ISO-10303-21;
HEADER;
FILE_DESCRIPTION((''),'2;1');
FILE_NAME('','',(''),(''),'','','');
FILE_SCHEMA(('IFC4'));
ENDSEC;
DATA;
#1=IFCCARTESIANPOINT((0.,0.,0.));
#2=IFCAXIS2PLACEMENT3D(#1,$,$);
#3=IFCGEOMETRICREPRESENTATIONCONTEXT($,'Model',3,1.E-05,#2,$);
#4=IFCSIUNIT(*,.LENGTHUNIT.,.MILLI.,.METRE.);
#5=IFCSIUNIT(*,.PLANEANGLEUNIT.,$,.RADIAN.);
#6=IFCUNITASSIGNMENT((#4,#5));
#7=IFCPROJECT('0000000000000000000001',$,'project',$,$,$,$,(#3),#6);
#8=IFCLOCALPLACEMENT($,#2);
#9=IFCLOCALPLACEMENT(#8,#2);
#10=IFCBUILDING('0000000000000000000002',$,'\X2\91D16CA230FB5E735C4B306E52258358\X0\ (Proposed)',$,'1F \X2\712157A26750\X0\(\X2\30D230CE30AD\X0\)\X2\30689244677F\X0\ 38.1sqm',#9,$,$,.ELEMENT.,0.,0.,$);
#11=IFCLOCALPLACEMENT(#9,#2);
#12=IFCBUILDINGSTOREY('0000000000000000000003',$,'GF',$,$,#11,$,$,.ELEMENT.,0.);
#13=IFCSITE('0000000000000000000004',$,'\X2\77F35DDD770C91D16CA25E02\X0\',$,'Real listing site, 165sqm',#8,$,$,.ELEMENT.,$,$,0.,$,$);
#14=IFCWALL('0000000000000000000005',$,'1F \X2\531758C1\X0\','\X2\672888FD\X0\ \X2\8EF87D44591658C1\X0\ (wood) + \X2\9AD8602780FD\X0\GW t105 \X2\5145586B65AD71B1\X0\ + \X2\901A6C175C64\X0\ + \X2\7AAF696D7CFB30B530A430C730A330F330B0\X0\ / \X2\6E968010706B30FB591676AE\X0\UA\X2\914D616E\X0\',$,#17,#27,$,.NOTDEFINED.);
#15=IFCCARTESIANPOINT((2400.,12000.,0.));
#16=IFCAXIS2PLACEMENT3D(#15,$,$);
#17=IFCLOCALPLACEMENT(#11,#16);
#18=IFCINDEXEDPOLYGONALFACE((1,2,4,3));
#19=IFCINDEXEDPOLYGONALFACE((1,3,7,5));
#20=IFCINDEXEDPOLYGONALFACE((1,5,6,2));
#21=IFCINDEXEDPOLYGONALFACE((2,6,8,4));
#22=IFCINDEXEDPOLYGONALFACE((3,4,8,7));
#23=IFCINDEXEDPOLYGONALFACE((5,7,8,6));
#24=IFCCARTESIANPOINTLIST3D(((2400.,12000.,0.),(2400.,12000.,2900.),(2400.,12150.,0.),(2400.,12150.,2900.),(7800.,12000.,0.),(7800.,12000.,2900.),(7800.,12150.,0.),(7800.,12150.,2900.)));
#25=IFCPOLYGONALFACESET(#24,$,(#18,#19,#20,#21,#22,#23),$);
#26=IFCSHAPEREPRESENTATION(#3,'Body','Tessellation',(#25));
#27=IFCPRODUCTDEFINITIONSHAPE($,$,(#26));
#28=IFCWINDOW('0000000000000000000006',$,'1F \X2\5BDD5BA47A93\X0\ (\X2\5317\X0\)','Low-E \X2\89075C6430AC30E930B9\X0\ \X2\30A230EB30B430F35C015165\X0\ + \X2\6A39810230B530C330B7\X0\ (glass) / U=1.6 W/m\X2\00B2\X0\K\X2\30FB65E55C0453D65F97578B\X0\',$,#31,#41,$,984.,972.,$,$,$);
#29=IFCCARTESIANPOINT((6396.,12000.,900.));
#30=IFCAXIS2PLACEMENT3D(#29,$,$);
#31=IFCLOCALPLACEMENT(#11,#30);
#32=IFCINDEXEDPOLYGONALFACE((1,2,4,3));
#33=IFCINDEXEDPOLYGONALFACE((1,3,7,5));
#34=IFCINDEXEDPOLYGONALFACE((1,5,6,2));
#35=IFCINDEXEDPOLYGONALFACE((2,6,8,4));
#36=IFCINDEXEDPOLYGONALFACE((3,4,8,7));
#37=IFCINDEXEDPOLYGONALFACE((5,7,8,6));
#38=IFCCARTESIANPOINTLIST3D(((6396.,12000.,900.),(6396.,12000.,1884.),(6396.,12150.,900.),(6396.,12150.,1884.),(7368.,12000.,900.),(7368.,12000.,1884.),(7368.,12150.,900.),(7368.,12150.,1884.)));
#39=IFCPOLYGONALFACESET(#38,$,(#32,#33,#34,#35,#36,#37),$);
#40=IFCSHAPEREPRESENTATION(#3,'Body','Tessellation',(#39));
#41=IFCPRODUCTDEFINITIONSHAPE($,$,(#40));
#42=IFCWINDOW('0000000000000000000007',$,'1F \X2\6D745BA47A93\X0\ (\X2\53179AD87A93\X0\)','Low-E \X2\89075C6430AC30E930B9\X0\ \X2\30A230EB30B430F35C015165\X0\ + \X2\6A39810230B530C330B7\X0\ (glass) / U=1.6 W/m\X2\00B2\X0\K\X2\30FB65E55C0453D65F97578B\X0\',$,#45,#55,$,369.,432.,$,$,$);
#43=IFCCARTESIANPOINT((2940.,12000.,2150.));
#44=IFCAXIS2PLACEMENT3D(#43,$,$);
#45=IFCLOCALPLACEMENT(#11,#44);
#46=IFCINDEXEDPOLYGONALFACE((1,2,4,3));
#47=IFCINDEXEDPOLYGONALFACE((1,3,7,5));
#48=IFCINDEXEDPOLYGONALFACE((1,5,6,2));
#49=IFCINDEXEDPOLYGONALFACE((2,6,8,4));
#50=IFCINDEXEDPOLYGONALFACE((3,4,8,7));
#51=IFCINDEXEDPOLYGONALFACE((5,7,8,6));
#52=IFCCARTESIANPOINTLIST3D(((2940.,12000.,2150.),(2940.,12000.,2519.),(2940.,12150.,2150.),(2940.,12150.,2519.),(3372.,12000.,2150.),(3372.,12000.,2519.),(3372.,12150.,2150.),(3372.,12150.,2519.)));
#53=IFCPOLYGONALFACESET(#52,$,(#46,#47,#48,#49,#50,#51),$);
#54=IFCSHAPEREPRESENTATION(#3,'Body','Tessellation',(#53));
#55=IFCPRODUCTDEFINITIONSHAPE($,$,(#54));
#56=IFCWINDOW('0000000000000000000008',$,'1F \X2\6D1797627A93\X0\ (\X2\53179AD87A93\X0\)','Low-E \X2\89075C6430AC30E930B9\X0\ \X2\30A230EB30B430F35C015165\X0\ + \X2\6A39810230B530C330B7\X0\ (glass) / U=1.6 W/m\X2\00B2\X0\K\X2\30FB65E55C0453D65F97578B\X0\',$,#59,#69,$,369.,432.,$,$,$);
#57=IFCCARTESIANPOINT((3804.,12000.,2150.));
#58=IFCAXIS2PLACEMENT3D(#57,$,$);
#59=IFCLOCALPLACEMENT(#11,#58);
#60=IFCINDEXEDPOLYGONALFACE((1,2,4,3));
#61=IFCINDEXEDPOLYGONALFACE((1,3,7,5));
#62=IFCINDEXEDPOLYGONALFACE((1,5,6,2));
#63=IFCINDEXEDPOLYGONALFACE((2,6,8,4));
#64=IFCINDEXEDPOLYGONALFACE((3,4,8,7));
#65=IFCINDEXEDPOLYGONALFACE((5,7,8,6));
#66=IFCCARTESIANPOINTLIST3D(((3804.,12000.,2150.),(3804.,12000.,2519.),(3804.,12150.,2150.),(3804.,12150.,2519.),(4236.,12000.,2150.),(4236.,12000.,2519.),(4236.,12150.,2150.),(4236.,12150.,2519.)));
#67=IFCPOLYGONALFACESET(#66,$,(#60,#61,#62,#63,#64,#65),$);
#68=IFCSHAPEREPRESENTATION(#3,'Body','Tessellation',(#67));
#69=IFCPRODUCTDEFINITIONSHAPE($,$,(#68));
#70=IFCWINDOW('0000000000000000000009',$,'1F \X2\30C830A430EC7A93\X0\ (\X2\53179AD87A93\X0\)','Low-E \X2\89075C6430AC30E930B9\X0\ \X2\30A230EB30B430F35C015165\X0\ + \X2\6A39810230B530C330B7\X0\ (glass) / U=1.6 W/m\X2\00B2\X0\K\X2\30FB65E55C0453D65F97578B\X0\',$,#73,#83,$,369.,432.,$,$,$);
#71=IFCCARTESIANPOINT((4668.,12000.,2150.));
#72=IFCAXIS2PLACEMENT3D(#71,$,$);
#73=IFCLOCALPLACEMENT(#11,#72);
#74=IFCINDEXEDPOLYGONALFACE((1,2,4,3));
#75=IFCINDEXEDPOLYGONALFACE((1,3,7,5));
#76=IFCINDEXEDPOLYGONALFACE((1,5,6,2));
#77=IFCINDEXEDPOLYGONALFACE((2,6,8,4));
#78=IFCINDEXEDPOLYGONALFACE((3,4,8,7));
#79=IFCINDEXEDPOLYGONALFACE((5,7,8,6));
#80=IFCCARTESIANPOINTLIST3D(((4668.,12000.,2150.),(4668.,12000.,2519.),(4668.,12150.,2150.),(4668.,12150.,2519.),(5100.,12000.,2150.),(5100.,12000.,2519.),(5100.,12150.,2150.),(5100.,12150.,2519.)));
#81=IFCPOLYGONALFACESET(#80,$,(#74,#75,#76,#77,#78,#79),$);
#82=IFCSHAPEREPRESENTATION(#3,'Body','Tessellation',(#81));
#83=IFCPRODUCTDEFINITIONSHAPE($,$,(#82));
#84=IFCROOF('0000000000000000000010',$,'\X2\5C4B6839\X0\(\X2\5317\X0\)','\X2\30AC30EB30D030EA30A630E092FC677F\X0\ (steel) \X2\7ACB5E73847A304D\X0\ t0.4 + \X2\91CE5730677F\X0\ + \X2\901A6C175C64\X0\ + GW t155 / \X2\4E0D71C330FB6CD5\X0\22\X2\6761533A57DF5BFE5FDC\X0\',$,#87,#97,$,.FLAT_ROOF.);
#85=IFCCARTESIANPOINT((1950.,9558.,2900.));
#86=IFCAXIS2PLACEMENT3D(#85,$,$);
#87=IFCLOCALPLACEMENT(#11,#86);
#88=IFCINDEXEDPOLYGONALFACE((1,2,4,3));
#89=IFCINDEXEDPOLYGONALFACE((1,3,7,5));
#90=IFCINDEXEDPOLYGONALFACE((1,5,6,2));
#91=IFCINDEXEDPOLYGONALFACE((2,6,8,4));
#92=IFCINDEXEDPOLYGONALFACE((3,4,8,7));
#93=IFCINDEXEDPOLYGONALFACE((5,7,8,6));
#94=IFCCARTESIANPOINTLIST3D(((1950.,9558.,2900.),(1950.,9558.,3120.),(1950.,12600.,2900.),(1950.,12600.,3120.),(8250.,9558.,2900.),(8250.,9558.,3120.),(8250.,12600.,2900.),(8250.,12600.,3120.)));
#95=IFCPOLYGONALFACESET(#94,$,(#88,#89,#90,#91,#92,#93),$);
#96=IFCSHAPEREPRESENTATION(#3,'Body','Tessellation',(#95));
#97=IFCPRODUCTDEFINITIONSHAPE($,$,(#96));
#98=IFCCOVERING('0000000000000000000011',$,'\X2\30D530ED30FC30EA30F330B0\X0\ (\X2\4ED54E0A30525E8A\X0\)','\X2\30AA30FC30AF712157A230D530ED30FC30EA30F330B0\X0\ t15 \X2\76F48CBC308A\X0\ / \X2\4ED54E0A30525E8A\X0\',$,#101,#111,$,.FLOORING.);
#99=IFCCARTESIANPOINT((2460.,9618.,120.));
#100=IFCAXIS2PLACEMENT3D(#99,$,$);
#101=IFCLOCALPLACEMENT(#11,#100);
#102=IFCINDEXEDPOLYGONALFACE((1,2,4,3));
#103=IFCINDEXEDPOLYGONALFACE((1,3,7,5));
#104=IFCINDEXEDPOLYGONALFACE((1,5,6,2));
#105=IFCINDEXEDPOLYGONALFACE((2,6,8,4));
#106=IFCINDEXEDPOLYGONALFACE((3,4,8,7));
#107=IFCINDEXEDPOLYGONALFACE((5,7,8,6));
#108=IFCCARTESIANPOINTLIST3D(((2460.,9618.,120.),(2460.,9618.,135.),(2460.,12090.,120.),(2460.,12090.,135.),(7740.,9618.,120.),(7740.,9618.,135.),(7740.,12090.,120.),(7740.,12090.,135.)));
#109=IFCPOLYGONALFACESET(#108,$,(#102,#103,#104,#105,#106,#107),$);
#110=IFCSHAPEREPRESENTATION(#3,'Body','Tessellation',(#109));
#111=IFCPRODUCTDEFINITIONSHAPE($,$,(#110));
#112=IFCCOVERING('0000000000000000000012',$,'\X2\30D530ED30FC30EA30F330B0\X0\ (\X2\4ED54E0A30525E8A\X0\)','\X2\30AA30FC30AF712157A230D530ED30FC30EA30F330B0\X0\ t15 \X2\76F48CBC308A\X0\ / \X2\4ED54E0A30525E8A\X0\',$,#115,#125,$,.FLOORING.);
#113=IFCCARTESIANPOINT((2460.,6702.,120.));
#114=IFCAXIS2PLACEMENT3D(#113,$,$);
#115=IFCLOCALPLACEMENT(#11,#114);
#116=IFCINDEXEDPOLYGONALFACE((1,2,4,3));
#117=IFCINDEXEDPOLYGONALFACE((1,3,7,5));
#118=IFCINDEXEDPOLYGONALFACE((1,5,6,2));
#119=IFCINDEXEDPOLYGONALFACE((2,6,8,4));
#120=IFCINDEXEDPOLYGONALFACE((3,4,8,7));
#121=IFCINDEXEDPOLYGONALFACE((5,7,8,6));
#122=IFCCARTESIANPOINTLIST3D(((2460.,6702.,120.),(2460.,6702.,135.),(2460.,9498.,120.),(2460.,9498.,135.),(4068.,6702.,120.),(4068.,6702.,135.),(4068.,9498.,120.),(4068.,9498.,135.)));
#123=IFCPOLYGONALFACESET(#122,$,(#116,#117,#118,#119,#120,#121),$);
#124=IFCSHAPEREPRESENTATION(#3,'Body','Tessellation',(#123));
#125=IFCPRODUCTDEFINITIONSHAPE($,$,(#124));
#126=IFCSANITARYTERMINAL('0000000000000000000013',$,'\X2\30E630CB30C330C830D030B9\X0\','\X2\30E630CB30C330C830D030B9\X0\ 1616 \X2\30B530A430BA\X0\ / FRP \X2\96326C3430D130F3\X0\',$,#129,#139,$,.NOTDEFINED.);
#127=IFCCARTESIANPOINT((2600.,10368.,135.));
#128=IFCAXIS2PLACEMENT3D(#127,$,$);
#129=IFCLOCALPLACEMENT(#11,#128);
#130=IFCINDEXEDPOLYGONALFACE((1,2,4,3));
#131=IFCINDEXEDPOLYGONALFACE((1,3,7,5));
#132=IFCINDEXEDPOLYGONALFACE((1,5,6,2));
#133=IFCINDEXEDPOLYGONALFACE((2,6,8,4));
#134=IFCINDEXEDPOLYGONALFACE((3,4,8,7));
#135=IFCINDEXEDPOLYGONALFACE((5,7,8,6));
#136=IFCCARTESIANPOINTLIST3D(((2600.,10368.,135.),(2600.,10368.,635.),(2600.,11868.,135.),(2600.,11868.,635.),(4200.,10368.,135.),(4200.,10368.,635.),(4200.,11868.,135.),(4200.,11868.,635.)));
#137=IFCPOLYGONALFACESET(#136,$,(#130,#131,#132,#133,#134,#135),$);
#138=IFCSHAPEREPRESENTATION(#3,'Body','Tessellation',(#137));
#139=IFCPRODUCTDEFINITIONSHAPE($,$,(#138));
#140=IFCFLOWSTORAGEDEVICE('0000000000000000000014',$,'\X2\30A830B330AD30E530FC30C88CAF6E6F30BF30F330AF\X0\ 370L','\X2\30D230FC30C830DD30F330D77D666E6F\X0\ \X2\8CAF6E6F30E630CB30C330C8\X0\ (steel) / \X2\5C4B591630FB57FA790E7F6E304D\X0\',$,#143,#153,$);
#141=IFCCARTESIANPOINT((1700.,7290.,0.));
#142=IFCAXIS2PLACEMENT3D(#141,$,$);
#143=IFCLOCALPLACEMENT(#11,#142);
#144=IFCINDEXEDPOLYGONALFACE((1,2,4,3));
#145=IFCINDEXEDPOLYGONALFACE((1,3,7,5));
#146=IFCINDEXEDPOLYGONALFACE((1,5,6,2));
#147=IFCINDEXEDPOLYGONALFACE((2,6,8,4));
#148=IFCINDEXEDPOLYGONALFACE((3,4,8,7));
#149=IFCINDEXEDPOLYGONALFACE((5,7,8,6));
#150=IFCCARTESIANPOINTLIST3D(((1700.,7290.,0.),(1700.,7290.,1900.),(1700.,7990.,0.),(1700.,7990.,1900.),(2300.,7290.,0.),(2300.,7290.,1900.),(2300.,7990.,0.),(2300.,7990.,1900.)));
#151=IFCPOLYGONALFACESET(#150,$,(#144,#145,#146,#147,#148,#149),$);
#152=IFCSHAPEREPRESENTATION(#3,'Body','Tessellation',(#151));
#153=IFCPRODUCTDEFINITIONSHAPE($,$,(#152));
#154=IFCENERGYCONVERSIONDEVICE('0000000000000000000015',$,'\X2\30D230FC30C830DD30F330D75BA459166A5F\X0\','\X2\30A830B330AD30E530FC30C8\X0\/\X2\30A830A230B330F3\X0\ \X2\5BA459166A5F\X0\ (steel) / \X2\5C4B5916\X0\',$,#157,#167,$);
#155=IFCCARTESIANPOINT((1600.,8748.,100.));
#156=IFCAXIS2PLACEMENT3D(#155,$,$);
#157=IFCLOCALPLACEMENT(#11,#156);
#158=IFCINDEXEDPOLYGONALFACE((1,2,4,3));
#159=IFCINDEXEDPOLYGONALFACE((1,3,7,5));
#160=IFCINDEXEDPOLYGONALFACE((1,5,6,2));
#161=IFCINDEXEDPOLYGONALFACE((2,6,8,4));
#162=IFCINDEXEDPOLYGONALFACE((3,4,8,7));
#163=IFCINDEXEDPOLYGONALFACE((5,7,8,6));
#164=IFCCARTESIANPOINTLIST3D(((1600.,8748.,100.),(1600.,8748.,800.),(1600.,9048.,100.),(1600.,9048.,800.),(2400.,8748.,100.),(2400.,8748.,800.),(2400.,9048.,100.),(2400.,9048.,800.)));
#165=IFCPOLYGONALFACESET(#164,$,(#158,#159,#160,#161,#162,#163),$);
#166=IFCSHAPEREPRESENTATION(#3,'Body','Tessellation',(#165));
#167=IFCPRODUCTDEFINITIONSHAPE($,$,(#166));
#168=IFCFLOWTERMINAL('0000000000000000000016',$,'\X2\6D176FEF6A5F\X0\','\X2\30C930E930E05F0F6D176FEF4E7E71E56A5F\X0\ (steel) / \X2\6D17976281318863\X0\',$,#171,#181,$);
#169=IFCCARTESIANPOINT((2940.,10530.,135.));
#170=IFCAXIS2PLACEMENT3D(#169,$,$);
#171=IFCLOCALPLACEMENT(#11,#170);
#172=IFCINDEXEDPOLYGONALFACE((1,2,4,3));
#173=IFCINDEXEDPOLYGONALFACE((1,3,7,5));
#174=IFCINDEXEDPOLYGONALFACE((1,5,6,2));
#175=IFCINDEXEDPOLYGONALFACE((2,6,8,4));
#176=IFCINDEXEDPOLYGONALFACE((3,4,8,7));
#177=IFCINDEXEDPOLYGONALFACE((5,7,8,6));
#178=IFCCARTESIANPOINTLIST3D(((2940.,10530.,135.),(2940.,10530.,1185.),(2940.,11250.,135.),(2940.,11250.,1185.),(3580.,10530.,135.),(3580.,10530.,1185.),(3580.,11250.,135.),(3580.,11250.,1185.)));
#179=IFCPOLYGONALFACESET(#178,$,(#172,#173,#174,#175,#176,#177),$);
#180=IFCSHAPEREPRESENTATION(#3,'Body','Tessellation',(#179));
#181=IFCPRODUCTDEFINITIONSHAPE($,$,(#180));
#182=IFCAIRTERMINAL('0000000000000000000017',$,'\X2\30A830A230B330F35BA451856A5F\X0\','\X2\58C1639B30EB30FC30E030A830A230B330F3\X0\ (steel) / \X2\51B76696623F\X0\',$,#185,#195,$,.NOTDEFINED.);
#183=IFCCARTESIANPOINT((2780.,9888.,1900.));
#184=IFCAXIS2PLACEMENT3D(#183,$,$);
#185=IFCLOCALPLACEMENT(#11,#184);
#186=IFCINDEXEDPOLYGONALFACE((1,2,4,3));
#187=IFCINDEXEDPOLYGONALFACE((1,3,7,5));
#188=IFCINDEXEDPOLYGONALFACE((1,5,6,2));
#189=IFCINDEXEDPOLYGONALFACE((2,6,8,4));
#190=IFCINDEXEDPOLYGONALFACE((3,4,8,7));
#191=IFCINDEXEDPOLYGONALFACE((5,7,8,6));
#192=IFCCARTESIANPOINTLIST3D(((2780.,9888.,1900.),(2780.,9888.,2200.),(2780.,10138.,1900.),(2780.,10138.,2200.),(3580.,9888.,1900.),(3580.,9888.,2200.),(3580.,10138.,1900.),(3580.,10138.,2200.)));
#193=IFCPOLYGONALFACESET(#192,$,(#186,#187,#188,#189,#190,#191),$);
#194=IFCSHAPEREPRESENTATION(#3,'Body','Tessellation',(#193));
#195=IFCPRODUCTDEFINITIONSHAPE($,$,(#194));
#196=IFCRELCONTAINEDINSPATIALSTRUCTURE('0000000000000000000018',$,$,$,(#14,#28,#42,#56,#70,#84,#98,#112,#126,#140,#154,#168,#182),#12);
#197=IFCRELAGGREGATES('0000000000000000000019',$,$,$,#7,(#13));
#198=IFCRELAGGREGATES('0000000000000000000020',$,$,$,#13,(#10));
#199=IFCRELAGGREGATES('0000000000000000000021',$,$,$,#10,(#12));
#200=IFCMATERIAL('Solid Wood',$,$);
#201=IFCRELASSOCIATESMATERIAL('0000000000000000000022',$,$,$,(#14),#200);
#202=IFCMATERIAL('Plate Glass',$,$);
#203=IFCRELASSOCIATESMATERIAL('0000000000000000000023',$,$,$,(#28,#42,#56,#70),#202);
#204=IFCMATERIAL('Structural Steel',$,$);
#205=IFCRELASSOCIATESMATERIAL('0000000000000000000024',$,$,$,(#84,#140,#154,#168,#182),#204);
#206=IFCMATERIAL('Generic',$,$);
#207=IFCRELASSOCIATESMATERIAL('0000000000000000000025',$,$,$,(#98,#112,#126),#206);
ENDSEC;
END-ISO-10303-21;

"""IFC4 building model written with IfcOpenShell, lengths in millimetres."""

from ifc_helpers import new_model, si_unit, frame, frame_2d, origin, place, context, project, spatial, rectangle, extrude, material, element, fill, save


model = new_model("IFC4")

# Units and contexts
model_context = context("Model", 3, precision=1e-05, world=origin())
ifc_project = project(units=[si_unit("LENGTHUNIT", "METRE", prefix="MILLI"), si_unit("PLANEANGLEUNIT", "RADIAN")], contexts=[model_context])

# Site, building, storey
site_placement = place(None, origin())
site = spatial("IfcSite", under=ifc_project, at=site_placement, Name="石川県金沢市", ObjectType="Real listing site, 165sqm", CompositionType="ELEMENT", RefElevation=0.0)
building_placement = place(site_placement, origin())
building = spatial("IfcBuilding", under=site, at=building_placement, Name="金沢・平屋の別荘 (Proposed)", ObjectType="1F 無垢材(ヒノキ)と鉄板 38.1sqm", CompositionType="ELEMENT", ElevationOfRefHeight=0.0, ElevationOfTerrain=0.0)
storey_placement = place(building_placement, origin())
storey = spatial("IfcBuildingStorey", under=building, at=storey_placement, Name="GF", CompositionType="ELEMENT", Elevation=0.0)

# Shared definitions
ifc_material_1 = material(Name="Solid Wood")

# Wall, openings, windows
wall_1_placement = place(storey_placement, frame((2400.0, 12000.0, 0.0)))
wall_1 = element("IfcWall", 1, at=wall_1_placement, inside=storey, material=ifc_material_1, Name="1F 北壁", Description="木製 軸組外壁 (wood) + 高性能GW t105 充填断熱 + 通気層 + 窯業系サイディング / 準耐火・外皮UA配慮", PredefinedType="NOTDEFINED", context=model_context, shape_type="SweptSolid", body=[
    extrude(rectangle(XDim=5400.0, YDim=150.0, at=frame_2d((2700.0, 75.0))), frame((2400.0, 12000.0, 0.0)), (0.0, 0.0, 1.0), 2900.0),
])
opening_1_placement = place(storey_placement, frame((6396.0, 12000.0, 900.0)))
opening_1 = element("IfcOpeningElement", 2, at=opening_1_placement, cuts=wall_1, PredefinedType="NOTDEFINED", context=model_context, shape_type="SweptSolid", body=[
    extrude(rectangle(XDim=972.0, YDim=150.0, at=frame_2d((486.0, 75.0))), frame((6396.0, 12000.0, 900.0)), (0.0, 0.0, 1.0), 984.0),
])
opening_2_placement = place(storey_placement, frame((2940.0, 12000.0, 2150.0)))
opening_2 = element("IfcOpeningElement", 3, at=opening_2_placement, cuts=wall_1, PredefinedType="NOTDEFINED", context=model_context, shape_type="SweptSolid", body=[
    extrude(rectangle(XDim=432.0, YDim=150.0, at=frame_2d((216.0, 75.0))), frame((2940.0, 12000.0, 2150.0)), (0.0, 0.0, 1.0), 369.0),
])
opening_3_placement = place(storey_placement, frame((3804.0, 12000.0, 2150.0)))
opening_3 = element("IfcOpeningElement", 4, at=opening_3_placement, cuts=wall_1, PredefinedType="NOTDEFINED", context=model_context, shape_type="SweptSolid", body=[
    extrude(rectangle(XDim=432.0, YDim=150.0, at=frame_2d((216.0, 75.0))), frame((3804.0, 12000.0, 2150.0)), (0.0, 0.0, 1.0), 369.0),
])
opening_4_placement = place(storey_placement, frame((4668.0, 12000.0, 2150.0)))
opening_4 = element("IfcOpeningElement", 5, at=opening_4_placement, cuts=wall_1, PredefinedType="NOTDEFINED", context=model_context, shape_type="SweptSolid", body=[
    extrude(rectangle(XDim=432.0, YDim=150.0, at=frame_2d((216.0, 75.0))), frame((4668.0, 12000.0, 2150.0)), (0.0, 0.0, 1.0), 369.0),
])
ifc_material_2 = material(Name="Plate Glass")
window_1_placement = place(storey_placement, frame((6396.0, 12000.0, 900.0)))
window_1 = element("IfcWindow", 6, at=window_1_placement, inside=storey, material=ifc_material_2, Name="1F 寝室窓 (北)", Description="Low-E 複層ガラス アルゴン封入 + 樹脂サッシ (glass) / U=1.6 W/m²K・日射取得型", OverallHeight=984.0, OverallWidth=972.0, context=model_context, shape_type="SweptSolid", body=[
    extrude(rectangle(XDim=972.0, YDim=150.0, at=frame_2d((486.0, 75.0))), frame((6396.0, 12000.0, 900.0)), (0.0, 0.0, 1.0), 984.0),
])
fill(opening_1, window_1)
window_2_placement = place(storey_placement, frame((2940.0, 12000.0, 2150.0)))
window_2 = element("IfcWindow", 7, at=window_2_placement, inside=storey, material=ifc_material_2, Name="1F 浴室窓 (北高窓)", Description="Low-E 複層ガラス アルゴン封入 + 樹脂サッシ (glass) / U=1.6 W/m²K・日射取得型", OverallHeight=369.0, OverallWidth=432.0, context=model_context, shape_type="SweptSolid", body=[
    extrude(rectangle(XDim=432.0, YDim=150.0, at=frame_2d((216.0, 75.0))), frame((2940.0, 12000.0, 2150.0)), (0.0, 0.0, 1.0), 369.0),
])
fill(opening_2, window_2)
window_3_placement = place(storey_placement, frame((3804.0, 12000.0, 2150.0)))
window_3 = element("IfcWindow", 8, at=window_3_placement, inside=storey, material=ifc_material_2, Name="1F 洗面窓 (北高窓)", Description="Low-E 複層ガラス アルゴン封入 + 樹脂サッシ (glass) / U=1.6 W/m²K・日射取得型", OverallHeight=369.0, OverallWidth=432.0, context=model_context, shape_type="SweptSolid", body=[
    extrude(rectangle(XDim=432.0, YDim=150.0, at=frame_2d((216.0, 75.0))), frame((3804.0, 12000.0, 2150.0)), (0.0, 0.0, 1.0), 369.0),
])
fill(opening_3, window_3)
window_4_placement = place(storey_placement, frame((4668.0, 12000.0, 2150.0)))
window_4 = element("IfcWindow", 9, at=window_4_placement, inside=storey, material=ifc_material_2, Name="1F トイレ窓 (北高窓)", Description="Low-E 複層ガラス アルゴン封入 + 樹脂サッシ (glass) / U=1.6 W/m²K・日射取得型", OverallHeight=369.0, OverallWidth=432.0, context=model_context, shape_type="SweptSolid", body=[
    extrude(rectangle(XDim=432.0, YDim=150.0, at=frame_2d((216.0, 75.0))), frame((4668.0, 12000.0, 2150.0)), (0.0, 0.0, 1.0), 369.0),
])
fill(opening_4, window_4)

# Roof
ifc_material_3 = material(Name="Structural Steel")
roof_placement = place(storey_placement, frame((1950.0, 9558.0, 2900.0)))
element("IfcRoof", 10, at=roof_placement, inside=storey, material=ifc_material_3, Name="屋根(北)", Description="ガルバリウム鋼板 (steel) 立平葺き t0.4 + 野地板 + 通気層 + GW t155 / 不燃・法22条区域対応", PredefinedType="FLAT_ROOF", context=model_context, shape_type="SweptSolid", body=[
    extrude(rectangle(XDim=6300.0, YDim=3042.0, at=frame_2d((3150.0, 1521.0))), frame((1950.0, 9558.0, 2900.0)), (0.0, 0.0, 1.0), 220.0),
])

# Coverings
ifc_material_4 = material(Name="Generic")
covering_1_placement = place(storey_placement, frame((2460.0, 9618.0, 120.0)))
element("IfcCovering", 11, at=covering_1_placement, inside=storey, material=ifc_material_4, Name="フローリング (仕上げ床)", Description="オーク無垢フローリング t15 直貼り / 仕上げ床", PredefinedType="FLOORING", context=model_context, shape_type="SweptSolid", body=[
    extrude(rectangle(XDim=5280.0, YDim=2472.0, at=frame_2d((2640.0, 1236.0))), frame((2460.0, 9618.0, 120.0)), (0.0, 0.0, 1.0), 15.0),
])
covering_2_placement = place(storey_placement, frame((2460.0, 6702.0, 120.0)))
element("IfcCovering", 12, at=covering_2_placement, inside=storey, material=ifc_material_4, Name="フローリング (仕上げ床)", Description="オーク無垢フローリング t15 直貼り / 仕上げ床", PredefinedType="FLOORING", context=model_context, shape_type="SweptSolid", body=[
    extrude(rectangle(XDim=1608.0, YDim=2796.0, at=frame_2d((804.0, 1398.0))), frame((2460.0, 6702.0, 120.0)), (0.0, 0.0, 1.0), 15.0),
])

# Sanitary terminal
sanitary_terminal_placement = place(storey_placement, frame((2600.0, 10368.0, 135.0)))
element("IfcSanitaryTerminal", 13, at=sanitary_terminal_placement, inside=storey, material=ifc_material_4, Name="ユニットバス", Description="ユニットバス 1616 サイズ / FRP 防水パン", PredefinedType="NOTDEFINED", context=model_context, shape_type="SweptSolid", body=[
    extrude(rectangle(XDim=1600.0, YDim=1500.0, at=frame_2d((800.0, 750.0))), frame((2600.0, 10368.0, 135.0)), (0.0, 0.0, 1.0), 500.0),
])

# Flow storage device
flow_storage_device_placement = place(storey_placement, frame((1700.0, 7290.0, 0.0)))
element("IfcFlowStorageDevice", 14, at=flow_storage_device_placement, inside=storey, material=ifc_material_3, Name="エコキュート貯湯タンク 370L", Description="ヒートポンプ給湯 貯湯ユニット (steel) / 屋外・基礎置き", context=model_context, shape_type="SweptSolid", body=[
    extrude(rectangle(XDim=600.0, YDim=700.0, at=frame_2d((300.0, 350.0))), frame((1700.0, 7290.0, 0.0)), (0.0, 0.0, 1.0), 1900.0),
])

# Energy conversion device
energy_conversion_device_placement = place(storey_placement, frame((1600.0, 8748.0, 100.0)))
element("IfcEnergyConversionDevice", 15, at=energy_conversion_device_placement, inside=storey, material=ifc_material_3, Name="ヒートポンプ室外機", Description="エコキュート/エアコン 室外機 (steel) / 屋外", context=model_context, shape_type="SweptSolid", body=[
    extrude(rectangle(XDim=800.0, YDim=300.0, at=frame_2d((400.0, 150.0))), frame((1600.0, 8748.0, 100.0)), (0.0, 0.0, 1.0), 700.0),
])

# Flow terminal
flow_terminal_placement = place(storey_placement, frame((2940.0, 10530.0, 135.0)))
element("IfcFlowTerminal", 16, at=flow_terminal_placement, inside=storey, material=ifc_material_3, Name="洗濯機", Description="ドラム式洗濯乾燥機 (steel) / 洗面脱衣", context=model_context, shape_type="SweptSolid", body=[
    extrude(rectangle(XDim=640.0, YDim=720.0, at=frame_2d((320.0, 360.0))), frame((2940.0, 10530.0, 135.0)), (0.0, 0.0, 1.0), 1050.0),
])

# Air terminal
air_terminal_placement = place(storey_placement, frame((2780.0, 9888.0, 1900.0)))
element("IfcAirTerminal", 17, at=air_terminal_placement, inside=storey, material=ifc_material_3, Name="エアコン室内機", Description="壁掛ルームエアコン (steel) / 冷暖房", PredefinedType="NOTDEFINED", context=model_context, shape_type="SweptSolid", body=[
    extrude(rectangle(XDim=800.0, YDim=250.0, at=frame_2d((400.0, 125.0))), frame((2780.0, 9888.0, 1900.0)), (0.0, 0.0, 1.0), 300.0),
])

save(model, "model.ifc")
